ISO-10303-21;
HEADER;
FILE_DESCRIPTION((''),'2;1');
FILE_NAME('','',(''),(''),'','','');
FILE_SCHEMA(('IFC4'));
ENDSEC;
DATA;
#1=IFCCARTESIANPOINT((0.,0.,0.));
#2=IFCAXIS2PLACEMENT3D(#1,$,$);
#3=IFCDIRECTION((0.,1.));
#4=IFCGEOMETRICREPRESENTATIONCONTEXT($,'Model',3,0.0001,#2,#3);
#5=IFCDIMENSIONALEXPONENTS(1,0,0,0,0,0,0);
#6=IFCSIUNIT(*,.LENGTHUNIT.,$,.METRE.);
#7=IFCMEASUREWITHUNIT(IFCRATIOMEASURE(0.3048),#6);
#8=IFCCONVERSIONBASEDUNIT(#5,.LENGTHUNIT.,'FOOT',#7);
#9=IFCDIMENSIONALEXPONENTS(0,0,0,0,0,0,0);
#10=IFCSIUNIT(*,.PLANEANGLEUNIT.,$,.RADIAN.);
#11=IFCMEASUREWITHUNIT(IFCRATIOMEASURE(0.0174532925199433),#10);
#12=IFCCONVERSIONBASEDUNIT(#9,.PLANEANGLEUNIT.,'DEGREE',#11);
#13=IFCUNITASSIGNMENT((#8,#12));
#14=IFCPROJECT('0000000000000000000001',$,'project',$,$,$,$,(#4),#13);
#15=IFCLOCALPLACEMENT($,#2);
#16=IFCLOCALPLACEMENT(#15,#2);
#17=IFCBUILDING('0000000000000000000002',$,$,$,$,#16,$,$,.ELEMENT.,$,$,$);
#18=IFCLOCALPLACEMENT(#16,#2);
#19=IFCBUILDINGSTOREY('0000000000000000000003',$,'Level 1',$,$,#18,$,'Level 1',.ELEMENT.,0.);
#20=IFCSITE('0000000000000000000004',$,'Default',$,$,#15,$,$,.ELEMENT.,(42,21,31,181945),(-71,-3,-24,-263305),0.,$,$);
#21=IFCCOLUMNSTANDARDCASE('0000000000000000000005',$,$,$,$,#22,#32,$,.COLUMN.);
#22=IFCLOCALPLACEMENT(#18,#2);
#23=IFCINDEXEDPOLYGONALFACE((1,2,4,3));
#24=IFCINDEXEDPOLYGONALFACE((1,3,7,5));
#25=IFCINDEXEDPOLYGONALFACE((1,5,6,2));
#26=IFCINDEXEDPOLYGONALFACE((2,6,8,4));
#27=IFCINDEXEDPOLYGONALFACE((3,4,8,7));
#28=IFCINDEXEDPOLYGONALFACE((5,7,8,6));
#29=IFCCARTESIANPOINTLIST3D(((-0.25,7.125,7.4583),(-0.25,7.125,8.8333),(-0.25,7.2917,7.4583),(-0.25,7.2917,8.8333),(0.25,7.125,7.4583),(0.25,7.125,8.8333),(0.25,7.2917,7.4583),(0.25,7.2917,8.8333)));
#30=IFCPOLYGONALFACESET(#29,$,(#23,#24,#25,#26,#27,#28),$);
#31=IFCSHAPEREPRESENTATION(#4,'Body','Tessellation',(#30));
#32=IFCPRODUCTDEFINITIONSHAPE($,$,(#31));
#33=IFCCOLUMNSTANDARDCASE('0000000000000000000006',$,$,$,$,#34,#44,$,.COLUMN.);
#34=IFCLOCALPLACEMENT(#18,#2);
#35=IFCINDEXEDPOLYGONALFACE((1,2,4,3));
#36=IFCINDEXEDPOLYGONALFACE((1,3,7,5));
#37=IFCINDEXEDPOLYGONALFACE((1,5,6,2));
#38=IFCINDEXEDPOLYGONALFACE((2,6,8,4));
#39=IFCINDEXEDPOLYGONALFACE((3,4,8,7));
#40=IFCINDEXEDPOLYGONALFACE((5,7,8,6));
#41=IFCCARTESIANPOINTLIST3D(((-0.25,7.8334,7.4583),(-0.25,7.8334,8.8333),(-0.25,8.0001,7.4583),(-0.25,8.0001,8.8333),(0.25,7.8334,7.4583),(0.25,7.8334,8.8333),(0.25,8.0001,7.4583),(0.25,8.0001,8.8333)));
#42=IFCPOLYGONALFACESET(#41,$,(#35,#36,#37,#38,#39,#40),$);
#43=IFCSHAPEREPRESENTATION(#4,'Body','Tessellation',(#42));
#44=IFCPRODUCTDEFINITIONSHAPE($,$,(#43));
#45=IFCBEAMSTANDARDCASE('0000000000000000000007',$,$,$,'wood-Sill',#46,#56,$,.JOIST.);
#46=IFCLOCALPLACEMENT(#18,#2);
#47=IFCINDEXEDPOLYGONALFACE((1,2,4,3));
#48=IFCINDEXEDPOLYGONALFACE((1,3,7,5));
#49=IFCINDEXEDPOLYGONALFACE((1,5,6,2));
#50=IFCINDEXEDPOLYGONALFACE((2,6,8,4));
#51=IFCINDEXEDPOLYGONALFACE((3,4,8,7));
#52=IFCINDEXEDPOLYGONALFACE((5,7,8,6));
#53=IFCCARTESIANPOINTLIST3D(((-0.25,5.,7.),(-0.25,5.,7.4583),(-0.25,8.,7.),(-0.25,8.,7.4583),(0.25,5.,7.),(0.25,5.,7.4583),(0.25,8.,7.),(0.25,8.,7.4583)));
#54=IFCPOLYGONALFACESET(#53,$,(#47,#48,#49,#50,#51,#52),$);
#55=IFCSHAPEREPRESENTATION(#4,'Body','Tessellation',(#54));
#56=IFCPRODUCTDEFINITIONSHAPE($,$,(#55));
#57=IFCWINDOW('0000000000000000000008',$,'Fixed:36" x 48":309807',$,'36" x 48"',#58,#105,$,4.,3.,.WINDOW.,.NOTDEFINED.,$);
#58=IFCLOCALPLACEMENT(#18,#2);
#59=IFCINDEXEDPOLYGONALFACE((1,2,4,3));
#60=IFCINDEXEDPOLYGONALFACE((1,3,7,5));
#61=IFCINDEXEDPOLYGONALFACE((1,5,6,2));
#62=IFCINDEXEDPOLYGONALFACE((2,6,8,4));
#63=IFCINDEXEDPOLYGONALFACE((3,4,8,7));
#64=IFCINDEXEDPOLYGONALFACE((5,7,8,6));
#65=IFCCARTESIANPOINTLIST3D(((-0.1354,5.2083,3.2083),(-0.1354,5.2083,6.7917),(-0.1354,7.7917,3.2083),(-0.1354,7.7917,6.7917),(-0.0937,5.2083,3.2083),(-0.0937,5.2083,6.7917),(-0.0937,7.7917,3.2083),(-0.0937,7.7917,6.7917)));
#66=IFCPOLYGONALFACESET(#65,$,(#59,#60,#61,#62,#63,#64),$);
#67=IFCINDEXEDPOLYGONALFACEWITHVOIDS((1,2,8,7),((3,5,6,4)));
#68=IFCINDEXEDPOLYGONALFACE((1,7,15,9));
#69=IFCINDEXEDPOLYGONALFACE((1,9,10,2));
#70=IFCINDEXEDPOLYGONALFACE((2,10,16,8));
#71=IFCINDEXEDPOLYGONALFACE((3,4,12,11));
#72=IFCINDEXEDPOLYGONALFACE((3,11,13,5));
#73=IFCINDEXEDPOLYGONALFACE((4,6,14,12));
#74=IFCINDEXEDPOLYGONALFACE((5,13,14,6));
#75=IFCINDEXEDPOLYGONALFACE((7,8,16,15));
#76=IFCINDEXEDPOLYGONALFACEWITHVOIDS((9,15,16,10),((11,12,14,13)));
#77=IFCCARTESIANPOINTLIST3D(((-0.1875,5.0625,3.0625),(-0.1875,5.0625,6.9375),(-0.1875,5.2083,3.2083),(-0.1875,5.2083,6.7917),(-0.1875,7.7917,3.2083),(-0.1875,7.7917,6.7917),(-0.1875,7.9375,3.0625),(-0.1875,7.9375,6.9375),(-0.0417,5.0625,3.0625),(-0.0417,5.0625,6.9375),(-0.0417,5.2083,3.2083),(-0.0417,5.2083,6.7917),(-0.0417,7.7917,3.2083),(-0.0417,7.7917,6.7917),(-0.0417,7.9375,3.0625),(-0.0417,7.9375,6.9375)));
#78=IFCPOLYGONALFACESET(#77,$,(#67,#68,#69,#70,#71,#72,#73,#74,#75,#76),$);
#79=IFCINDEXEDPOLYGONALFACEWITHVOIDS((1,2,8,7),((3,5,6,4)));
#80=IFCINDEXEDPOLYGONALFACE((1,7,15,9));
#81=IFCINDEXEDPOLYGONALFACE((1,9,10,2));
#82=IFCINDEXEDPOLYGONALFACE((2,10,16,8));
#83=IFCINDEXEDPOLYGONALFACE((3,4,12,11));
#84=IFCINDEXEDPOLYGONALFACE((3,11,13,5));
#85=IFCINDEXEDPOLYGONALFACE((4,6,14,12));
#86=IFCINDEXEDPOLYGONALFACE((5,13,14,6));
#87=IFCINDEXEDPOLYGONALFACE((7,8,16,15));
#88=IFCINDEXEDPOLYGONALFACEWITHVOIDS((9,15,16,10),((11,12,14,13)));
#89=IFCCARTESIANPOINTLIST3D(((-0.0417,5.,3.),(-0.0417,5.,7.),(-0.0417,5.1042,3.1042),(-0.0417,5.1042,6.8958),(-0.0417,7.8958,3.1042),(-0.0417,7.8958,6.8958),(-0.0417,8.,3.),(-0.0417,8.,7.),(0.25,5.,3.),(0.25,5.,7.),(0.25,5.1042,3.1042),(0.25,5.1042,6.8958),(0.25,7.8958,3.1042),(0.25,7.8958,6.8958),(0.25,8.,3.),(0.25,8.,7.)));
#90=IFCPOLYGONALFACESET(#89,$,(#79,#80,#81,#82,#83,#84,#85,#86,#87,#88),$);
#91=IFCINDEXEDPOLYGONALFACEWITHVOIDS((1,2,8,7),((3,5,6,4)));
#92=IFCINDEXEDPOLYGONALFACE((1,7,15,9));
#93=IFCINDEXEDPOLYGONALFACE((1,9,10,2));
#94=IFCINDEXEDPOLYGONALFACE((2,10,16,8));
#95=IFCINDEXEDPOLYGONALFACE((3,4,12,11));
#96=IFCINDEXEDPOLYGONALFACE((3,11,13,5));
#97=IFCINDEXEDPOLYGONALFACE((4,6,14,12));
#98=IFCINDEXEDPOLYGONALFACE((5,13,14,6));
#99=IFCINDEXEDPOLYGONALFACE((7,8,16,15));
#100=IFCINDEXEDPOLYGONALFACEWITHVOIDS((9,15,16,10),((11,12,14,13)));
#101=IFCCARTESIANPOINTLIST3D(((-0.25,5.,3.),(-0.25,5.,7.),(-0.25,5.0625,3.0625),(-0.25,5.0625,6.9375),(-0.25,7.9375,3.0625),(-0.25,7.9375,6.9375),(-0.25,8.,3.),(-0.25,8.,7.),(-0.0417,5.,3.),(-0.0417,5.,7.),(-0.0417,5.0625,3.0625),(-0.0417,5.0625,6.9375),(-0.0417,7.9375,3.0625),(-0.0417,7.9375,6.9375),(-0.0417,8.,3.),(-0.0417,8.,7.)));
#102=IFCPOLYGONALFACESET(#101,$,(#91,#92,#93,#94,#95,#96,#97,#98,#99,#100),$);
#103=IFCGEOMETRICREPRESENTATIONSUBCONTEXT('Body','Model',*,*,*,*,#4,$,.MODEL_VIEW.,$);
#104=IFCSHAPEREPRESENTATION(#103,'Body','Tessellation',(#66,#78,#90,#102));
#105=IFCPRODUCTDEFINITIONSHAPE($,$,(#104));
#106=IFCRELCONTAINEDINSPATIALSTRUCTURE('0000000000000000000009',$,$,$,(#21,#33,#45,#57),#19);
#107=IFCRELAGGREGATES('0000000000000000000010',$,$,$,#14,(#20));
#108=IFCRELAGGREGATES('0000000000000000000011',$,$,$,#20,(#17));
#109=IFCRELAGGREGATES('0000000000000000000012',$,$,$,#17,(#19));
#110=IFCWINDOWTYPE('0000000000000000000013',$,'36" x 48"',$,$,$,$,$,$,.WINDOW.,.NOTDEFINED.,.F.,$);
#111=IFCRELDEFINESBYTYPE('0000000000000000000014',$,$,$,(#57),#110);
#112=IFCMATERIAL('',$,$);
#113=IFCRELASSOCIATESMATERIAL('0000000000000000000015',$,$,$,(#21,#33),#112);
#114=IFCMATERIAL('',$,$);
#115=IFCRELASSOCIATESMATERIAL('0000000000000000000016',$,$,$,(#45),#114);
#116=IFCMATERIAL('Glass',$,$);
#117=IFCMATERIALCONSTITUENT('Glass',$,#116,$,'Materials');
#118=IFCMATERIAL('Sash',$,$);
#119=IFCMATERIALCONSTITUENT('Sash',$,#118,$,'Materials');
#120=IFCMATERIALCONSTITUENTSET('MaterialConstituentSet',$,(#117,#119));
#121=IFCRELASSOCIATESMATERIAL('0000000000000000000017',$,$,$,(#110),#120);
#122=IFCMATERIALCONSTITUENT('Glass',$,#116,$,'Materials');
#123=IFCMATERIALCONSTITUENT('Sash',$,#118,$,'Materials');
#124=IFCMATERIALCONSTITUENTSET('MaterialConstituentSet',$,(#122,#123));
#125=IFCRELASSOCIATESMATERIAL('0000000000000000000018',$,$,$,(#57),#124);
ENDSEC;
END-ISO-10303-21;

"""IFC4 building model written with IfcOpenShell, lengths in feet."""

from ifc_helpers import new_model, entity, si_unit, converted_unit, direction, frame, frame_2d, origin, place, context, subcontext, project, spatial, polyline, rectangle, outline, extrude, source, transform, mapped, material, constituent, constituent_set, type_object, type_shapes, element, save


model = new_model("IFC4")

# Units and contexts
model_context = context("Model", 3, precision=0.0001, world=origin(), true_north=direction((0.0, 1.0)))
body_context = subcontext(model_context, "Body", "Model", "MODEL_VIEW")
ifc_project = project(units=[converted_unit("LENGTHUNIT", "FOOT", entity("IfcRatioMeasure", 0.3048), si_unit("LENGTHUNIT", "METRE"), dimensions=[1, 0, 0, 0, 0, 0, 0]), converted_unit("PLANEANGLEUNIT", "DEGREE", entity("IfcRatioMeasure", 0.0174532925199433), si_unit("PLANEANGLEUNIT", "RADIAN"), dimensions=[0, 0, 0, 0, 0, 0, 0])], contexts=[model_context])

# Site, building, storey
site_placement = place(None, origin())
site = spatial("IfcSite", under=ifc_project, at=site_placement, Name="Default", CompositionType="ELEMENT", RefLatitude=(42, 21, 31, 181945), RefLongitude=(-71, -3, -24, -263305), RefElevation=0.0)
building_placement = place(site_placement, origin())
building = spatial("IfcBuilding", under=site, at=building_placement, CompositionType="ELEMENT")
storey_placement = place(building_placement, origin())
storey = spatial("IfcBuildingStorey", under=building, at=storey_placement, Name="Level 1", LongName="Level 1", CompositionType="ELEMENT", Elevation=0.0)

# Columns
placement_1 = place(storey_placement, frame((0.0, -0.25, 0.0), z_axis=(0.0, 0.0, 1.0), x_axis=(0.0, 1.0, 0.0)))
ifc_material_1 = material(Name="")
for number, where, z_axis, x_axis in (
    (1, (7.4583, 0.0, 7.4583), (0.0, 0.0, 1.0), (1.0, 0.0, 0.0)),
    (2, (8.1667, 0.0, 7.4583), (0.0, 0.0, 1.0), (1.0, 0.0, 0.0)),
):
    element("IfcColumnStandardCase", number, at=place(placement_1, frame(where, z_axis=z_axis, x_axis=x_axis)), inside=storey, material=ifc_material_1, PredefinedType="COLUMN", context=model_context, shape_type="SweptSolid", body=[
        extrude(rectangle(XDim=0.1667, YDim=0.5), origin(), (0.0, 0.0, 1.0), 1.375),
    ])

# Beam
ifc_material_2 = material(Name="")
beam_placement = place(placement_1, frame((6.75, 0.0, 7.0), z_axis=(0.0, 0.0, 1.0), x_axis=(1.0, 0.0, 0.0)))
element("IfcBeamStandardCase", 3, at=beam_placement, inside=storey, material=ifc_material_2, ObjectType="wood-Sill", PredefinedType="JOIST", context=model_context, shape_type="SweptSolid", body=[
    extrude(rectangle(XDim=3.0, YDim=0.5), origin(), (0.0, 0.0, 1.0), 0.4583),
])

# Window
ifc_material_3 = material(Name="Glass")
ifc_constituent_1 = constituent(ifc_material_3, Name="Glass", Category="Materials")
ifc_material_4 = material(Name="Sash")
ifc_constituent_2 = constituent(ifc_material_4, Name="Sash", Category="Materials")
ifc_constituent_set_1 = constituent_set(constituents=[ifc_constituent_1, ifc_constituent_2], Name="MaterialConstituentSet")
ifc_constituent_3 = constituent(ifc_material_3, Name="Glass", Category="Materials")
ifc_constituent_4 = constituent(ifc_material_4, Name="Sash", Category="Materials")
ifc_constituent_set_2 = constituent_set(constituents=[ifc_constituent_3, ifc_constituent_4], Name="MaterialConstituentSet")
window_type = type_object("IfcWindowType", Name="36\" x 48\"", ParameterTakesPrecedence=False, PartitioningType="NOTDEFINED", PredefinedType="WINDOW", material=ifc_constituent_set_2)
shared_shape = source(origin(), body_context, "Body", "SweptSolid", [
    extrude(rectangle(XDim=0.0417, YDim=2.5833, at=frame_2d((0.0, 0.0), x_axis=(1.0, 0.0))), frame((1.5, 0.3646, 0.2083), z_axis=(0.0, 0.0, 1.0), x_axis=(0.0, 1.0, 0.0)), (0.0, 0.0, 1.0), 3.5833),
    extrude(outline(polyline([(-1.4375, -1.9375), (1.4375, -1.9375), (1.4375, 1.9375), (-1.4375, 1.9375), (-1.4375, -1.9375)]), holes=[polyline([(-1.2917, -1.7917), (-1.2917, 1.7917), (1.2917, 1.7917), (1.2917, -1.7917), (-1.2917, -1.7917)])]), frame((1.5, 0.2917, 2.0), z_axis=(0.0, 1.0, 0.0), x_axis=(1.0, 0.0, 0.0)), (0.0, 0.0, 1.0), 0.1458),
    extrude(outline(polyline([(-1.5, -2.0), (1.5, -2.0), (1.5, 2.0), (-1.5, 2.0), (-1.5, -2.0)]), holes=[polyline([(-1.3958, -1.8958), (-1.3958, 1.8958), (1.3958, 1.8958), (1.3958, -1.8958), (-1.3958, -1.8958)])]), frame((1.5, 0.0, 2.0), z_axis=(0.0, 1.0, 0.0), x_axis=(1.0, 0.0, 0.0)), (0.0, 0.0, 1.0), 0.2917),
    extrude(outline(polyline([(-2.0, -1.5), (2.0, -1.5), (2.0, 1.5), (-2.0, 1.5), (-2.0, -1.5)]), holes=[polyline([(-1.9375, -1.4375), (-1.9375, 1.4375), (1.9375, 1.4375), (1.9375, -1.4375), (-1.9375, -1.4375)])]), frame((1.5, 0.2917, 2.0), z_axis=(0.0, 1.0, 0.0), x_axis=(0.0, 0.0, -1.0)), (0.0, 0.0, 1.0), 0.2083),
])
type_shapes(window_type, [shared_shape])
placement_2 = place(placement_1, frame((5.25, -0.25, 3.0)))
window_placement = place(placement_2, origin())
element("IfcWindow", 4, at=window_placement, inside=storey, type_object=window_type, material=ifc_constituent_set_1, Name="Fixed:36\" x 48\":309807", ObjectType="36\" x 48\"", OverallHeight=4.0, OverallWidth=3.0, PartitioningType="NOTDEFINED", PredefinedType="WINDOW", context=body_context, shape_type="MappedRepresentation", body=[
    mapped(shared_shape, transform((0.0, 0.0, 0.0), scale=1.0)),
])

save(model, "model.ifc")
